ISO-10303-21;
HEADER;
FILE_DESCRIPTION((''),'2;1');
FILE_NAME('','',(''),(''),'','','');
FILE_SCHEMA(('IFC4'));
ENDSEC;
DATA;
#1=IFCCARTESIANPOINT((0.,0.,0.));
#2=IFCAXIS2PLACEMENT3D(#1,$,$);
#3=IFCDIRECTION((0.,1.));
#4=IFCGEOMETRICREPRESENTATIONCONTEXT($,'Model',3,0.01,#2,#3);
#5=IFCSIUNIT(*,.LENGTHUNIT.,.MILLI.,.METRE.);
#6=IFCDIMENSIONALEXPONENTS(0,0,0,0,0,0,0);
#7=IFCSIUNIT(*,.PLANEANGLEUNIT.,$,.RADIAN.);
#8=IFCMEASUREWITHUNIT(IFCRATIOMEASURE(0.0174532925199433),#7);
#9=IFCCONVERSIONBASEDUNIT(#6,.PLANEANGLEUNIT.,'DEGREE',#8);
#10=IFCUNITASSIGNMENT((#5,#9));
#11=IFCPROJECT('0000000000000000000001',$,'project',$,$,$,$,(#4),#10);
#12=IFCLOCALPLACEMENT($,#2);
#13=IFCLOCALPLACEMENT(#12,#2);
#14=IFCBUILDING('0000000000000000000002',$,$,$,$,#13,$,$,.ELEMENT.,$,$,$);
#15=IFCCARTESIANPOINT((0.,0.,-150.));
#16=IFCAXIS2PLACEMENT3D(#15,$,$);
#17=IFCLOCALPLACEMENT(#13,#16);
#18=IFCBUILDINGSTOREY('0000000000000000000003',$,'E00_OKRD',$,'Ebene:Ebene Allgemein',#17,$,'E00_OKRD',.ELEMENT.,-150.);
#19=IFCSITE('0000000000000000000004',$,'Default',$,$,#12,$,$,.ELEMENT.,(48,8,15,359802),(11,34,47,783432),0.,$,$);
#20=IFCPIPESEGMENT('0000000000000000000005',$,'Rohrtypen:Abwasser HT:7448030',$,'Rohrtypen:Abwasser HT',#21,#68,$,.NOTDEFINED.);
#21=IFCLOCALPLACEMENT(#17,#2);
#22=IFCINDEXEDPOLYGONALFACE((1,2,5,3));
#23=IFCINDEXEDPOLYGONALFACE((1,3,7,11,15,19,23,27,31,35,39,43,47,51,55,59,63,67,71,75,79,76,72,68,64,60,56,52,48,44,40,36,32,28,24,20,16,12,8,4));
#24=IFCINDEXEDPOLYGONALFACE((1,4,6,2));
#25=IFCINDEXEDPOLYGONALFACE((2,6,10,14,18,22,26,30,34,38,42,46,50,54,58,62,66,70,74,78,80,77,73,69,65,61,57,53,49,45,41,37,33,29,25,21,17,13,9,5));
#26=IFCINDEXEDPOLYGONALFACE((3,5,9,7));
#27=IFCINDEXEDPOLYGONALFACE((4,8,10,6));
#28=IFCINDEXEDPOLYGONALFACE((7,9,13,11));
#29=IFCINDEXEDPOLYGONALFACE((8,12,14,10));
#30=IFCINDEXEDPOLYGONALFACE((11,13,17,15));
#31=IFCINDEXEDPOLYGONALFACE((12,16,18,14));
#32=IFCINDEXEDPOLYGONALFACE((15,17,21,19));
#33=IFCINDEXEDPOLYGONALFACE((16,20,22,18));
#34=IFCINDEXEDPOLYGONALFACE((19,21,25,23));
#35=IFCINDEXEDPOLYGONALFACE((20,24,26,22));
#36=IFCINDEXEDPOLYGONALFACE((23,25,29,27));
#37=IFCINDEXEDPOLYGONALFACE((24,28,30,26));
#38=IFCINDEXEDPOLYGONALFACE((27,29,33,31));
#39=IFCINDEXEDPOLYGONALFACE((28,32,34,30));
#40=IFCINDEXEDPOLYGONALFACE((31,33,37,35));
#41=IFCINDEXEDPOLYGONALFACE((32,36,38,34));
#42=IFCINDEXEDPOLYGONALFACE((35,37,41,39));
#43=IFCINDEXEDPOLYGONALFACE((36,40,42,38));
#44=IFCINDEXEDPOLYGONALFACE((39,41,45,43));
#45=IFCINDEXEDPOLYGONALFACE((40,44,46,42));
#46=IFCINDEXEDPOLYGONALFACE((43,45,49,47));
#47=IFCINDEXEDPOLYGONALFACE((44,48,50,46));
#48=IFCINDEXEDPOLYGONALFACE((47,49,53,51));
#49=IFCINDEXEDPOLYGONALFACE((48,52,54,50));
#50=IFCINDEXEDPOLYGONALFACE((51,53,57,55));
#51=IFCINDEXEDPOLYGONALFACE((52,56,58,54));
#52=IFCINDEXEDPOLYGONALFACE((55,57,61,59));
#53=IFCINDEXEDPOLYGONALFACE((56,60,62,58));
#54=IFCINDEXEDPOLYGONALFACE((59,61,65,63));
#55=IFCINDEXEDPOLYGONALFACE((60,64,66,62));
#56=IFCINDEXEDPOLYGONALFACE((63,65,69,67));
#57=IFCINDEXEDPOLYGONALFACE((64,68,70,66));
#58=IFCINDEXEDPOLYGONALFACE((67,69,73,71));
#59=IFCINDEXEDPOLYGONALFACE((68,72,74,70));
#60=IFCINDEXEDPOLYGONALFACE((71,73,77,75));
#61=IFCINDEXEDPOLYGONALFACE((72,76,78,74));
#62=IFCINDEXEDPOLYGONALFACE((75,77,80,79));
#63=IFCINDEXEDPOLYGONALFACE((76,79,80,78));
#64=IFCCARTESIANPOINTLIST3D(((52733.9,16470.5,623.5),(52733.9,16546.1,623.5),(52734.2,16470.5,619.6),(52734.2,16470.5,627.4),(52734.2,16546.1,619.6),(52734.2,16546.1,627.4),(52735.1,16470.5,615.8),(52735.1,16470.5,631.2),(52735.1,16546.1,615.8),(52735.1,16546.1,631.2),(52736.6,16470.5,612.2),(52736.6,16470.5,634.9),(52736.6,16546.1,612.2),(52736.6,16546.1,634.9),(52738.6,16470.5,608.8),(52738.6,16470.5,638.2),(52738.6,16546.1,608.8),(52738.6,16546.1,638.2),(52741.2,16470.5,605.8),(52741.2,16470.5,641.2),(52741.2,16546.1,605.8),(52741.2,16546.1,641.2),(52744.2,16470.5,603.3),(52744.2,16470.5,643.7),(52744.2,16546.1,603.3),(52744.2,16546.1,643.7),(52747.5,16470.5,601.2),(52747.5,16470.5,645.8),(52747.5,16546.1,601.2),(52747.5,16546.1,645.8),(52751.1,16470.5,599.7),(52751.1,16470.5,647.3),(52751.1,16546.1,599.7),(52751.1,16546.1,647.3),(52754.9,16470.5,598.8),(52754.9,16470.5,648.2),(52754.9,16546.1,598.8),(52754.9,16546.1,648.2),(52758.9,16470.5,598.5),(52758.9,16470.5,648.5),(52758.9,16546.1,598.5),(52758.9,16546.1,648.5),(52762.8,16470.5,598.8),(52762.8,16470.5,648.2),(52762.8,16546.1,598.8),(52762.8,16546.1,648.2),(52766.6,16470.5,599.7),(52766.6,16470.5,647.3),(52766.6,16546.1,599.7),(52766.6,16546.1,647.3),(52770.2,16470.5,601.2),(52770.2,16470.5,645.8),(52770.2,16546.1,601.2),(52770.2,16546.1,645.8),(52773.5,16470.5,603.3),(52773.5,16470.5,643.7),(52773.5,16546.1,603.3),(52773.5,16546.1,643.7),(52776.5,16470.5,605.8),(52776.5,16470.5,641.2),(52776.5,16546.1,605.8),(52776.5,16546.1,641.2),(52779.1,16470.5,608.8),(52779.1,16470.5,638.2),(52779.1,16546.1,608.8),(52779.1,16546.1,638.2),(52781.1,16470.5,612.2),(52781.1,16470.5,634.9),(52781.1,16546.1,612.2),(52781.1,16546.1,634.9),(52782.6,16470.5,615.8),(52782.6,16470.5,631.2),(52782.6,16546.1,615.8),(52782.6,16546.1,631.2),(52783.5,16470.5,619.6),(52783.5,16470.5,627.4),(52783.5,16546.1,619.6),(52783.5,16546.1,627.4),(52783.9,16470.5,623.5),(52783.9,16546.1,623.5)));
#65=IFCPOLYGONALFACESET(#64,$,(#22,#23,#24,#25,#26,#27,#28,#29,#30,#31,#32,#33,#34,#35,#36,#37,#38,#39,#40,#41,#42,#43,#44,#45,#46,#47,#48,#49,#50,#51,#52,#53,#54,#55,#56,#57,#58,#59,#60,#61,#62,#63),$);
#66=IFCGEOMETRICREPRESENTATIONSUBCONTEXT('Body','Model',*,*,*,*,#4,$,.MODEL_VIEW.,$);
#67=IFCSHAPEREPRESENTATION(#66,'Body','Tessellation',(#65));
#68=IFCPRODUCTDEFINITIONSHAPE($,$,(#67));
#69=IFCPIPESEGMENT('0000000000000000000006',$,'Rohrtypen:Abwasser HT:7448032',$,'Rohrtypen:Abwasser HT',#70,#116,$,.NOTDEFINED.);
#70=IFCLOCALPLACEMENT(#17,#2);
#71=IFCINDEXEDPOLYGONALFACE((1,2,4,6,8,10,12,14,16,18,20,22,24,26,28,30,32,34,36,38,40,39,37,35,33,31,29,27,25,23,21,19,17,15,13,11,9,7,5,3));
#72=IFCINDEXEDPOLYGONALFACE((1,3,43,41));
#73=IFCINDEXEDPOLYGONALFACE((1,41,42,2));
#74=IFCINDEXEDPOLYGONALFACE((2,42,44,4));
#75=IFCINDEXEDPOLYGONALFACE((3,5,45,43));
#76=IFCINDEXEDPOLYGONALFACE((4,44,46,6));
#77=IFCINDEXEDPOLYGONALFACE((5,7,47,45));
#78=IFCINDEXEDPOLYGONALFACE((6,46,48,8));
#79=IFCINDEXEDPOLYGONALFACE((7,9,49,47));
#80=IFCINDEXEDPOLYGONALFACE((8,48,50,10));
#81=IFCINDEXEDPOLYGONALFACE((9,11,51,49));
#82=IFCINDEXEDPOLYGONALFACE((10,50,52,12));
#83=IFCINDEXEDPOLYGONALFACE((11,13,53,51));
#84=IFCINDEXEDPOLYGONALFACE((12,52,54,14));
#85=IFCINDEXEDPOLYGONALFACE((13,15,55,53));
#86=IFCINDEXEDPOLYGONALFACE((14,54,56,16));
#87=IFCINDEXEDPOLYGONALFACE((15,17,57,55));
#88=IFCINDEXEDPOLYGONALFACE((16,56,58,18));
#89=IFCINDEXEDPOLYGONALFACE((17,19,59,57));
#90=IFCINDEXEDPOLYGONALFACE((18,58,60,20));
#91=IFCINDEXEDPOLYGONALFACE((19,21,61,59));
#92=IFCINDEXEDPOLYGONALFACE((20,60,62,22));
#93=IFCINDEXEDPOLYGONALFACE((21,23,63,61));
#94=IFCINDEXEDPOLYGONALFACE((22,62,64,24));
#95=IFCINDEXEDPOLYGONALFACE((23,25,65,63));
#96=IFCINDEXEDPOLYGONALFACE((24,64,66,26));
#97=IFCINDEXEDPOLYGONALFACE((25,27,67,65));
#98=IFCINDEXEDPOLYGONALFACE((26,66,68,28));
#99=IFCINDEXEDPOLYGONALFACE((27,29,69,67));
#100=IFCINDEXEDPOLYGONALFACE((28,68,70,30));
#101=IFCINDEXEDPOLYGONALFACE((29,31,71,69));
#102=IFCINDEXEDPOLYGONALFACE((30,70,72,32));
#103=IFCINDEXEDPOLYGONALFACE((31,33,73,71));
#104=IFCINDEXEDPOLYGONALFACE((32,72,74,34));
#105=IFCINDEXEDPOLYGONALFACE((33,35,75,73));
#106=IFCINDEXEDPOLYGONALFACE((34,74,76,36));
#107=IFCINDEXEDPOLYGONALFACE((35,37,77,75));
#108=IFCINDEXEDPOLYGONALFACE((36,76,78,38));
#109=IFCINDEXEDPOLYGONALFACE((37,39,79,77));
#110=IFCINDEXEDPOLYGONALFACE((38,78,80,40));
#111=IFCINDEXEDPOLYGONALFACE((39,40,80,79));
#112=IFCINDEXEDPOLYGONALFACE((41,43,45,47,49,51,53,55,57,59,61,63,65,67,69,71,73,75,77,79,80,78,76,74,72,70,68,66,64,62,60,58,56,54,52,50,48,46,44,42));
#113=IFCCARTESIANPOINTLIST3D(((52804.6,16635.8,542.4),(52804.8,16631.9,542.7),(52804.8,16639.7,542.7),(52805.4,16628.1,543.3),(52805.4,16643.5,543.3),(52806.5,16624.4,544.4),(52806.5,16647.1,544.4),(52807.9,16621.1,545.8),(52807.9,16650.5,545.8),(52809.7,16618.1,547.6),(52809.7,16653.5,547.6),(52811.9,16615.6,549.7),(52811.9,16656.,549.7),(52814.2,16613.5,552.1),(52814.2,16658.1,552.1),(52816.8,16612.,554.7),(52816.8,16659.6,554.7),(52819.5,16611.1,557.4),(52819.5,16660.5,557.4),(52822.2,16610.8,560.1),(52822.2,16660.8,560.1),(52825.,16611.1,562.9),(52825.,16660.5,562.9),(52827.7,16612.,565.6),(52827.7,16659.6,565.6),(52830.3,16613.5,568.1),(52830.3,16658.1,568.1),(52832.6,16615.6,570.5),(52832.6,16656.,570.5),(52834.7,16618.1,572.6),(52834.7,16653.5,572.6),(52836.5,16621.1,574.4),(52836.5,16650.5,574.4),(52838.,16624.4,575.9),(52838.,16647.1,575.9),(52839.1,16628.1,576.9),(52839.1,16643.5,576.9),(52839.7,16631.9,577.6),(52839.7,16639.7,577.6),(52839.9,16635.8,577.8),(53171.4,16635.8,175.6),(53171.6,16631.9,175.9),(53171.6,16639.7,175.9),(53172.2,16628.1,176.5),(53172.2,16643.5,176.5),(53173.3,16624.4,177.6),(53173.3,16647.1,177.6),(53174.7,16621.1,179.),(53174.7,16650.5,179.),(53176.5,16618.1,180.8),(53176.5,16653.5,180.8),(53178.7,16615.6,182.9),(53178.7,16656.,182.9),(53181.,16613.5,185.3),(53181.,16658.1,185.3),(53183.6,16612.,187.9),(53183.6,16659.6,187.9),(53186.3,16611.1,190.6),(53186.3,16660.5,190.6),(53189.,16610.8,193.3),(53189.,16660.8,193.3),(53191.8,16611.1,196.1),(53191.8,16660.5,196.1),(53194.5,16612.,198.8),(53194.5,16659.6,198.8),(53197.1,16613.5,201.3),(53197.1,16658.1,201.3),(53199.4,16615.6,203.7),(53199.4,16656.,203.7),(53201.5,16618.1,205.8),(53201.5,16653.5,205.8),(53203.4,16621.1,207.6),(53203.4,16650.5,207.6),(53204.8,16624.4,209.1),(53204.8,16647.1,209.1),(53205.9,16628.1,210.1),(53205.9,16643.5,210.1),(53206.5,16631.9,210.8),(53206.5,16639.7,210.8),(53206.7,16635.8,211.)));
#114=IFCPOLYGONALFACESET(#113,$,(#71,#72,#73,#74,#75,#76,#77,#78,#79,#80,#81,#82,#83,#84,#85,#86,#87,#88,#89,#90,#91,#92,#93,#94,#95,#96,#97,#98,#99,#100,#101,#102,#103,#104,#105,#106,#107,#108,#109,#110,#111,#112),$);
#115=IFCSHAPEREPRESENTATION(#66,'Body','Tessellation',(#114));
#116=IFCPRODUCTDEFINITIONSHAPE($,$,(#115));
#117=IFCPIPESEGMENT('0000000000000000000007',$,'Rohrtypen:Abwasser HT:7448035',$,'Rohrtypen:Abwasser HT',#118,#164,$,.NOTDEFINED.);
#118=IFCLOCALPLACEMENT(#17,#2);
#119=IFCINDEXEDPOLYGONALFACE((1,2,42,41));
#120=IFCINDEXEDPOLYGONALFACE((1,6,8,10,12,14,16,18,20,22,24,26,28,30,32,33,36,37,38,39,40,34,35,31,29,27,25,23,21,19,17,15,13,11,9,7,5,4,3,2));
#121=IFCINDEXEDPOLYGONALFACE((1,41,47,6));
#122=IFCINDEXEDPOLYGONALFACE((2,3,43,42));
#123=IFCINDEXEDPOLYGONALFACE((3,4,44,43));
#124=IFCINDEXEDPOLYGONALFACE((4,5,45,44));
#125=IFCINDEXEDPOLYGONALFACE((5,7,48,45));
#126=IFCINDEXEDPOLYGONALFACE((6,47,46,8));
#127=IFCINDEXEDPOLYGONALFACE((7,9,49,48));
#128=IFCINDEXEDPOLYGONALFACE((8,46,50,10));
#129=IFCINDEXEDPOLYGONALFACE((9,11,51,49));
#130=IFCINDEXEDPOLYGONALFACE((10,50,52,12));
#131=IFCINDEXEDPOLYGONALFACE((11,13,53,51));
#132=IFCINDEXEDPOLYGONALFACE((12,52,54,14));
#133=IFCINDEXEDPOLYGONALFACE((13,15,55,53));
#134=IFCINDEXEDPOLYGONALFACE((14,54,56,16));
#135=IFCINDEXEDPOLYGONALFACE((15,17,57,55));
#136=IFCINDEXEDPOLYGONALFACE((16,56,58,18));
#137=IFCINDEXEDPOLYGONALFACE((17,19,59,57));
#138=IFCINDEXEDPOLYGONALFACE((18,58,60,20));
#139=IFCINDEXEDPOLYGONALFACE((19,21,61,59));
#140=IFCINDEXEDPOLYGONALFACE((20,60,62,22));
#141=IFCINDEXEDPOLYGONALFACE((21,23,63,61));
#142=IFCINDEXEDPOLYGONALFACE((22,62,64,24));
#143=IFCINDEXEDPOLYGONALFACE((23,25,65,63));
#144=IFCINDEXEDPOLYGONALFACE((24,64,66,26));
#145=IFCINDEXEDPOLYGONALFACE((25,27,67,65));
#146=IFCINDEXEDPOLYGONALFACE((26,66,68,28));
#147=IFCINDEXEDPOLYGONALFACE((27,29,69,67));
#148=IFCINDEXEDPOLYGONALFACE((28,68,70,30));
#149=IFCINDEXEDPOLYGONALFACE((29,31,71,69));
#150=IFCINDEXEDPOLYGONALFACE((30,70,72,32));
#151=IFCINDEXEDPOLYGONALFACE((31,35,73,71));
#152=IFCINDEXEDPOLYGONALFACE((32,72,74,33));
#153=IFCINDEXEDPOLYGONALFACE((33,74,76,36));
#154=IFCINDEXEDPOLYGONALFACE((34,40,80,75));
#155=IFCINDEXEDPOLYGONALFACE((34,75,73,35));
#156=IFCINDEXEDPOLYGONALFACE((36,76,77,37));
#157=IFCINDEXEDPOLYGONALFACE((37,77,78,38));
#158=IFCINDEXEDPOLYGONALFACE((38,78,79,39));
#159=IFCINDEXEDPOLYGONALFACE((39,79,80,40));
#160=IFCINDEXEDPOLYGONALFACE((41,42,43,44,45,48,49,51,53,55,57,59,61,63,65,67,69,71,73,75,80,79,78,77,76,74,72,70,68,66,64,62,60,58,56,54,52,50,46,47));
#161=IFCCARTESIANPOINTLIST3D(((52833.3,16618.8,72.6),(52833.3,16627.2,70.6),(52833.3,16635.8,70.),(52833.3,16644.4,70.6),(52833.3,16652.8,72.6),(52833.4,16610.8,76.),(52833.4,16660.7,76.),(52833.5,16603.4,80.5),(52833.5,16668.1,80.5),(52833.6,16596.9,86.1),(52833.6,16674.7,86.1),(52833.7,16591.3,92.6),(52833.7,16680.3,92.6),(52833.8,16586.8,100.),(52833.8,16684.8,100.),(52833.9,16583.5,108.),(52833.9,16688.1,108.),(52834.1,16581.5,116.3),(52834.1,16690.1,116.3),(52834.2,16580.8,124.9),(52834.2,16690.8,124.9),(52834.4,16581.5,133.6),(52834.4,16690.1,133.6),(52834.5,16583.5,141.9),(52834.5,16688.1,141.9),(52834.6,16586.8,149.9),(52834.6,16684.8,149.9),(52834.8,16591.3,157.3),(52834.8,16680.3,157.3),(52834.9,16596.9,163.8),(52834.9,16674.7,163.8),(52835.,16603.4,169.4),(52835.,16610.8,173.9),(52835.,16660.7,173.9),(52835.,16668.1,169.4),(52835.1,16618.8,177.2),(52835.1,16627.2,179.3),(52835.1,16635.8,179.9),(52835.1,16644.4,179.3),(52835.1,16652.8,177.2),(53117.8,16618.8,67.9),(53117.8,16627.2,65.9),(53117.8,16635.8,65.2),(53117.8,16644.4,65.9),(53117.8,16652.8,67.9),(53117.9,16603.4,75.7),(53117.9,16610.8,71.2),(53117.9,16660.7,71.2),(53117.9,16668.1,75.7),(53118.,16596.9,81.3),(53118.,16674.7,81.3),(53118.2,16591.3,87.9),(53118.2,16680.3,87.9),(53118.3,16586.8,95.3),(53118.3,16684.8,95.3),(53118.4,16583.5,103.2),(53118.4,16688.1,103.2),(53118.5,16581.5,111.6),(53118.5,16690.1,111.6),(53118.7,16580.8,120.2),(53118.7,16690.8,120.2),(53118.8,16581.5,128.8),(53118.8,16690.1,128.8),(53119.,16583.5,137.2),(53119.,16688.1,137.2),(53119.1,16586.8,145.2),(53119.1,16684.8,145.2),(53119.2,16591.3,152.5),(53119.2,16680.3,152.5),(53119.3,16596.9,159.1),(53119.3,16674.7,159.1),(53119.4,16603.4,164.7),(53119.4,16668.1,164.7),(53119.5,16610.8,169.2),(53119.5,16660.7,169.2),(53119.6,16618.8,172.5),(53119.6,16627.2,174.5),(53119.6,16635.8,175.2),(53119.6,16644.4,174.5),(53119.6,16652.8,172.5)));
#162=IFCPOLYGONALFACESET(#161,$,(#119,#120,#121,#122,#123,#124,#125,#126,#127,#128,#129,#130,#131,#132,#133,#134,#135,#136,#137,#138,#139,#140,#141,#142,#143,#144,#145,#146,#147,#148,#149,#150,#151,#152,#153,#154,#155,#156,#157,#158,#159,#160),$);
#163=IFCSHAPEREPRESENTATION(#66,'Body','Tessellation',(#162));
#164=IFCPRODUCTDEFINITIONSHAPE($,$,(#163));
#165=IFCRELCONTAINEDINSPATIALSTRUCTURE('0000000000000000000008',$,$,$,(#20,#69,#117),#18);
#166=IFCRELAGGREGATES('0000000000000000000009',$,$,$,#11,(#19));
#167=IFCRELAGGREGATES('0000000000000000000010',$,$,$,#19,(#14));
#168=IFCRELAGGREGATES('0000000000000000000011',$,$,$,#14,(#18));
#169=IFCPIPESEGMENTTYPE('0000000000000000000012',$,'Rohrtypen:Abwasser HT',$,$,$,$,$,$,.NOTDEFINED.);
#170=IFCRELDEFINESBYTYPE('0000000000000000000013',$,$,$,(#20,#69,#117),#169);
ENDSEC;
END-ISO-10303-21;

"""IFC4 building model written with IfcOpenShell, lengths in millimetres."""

from ifc_helpers import new_model, entity, si_unit, converted_unit, direction, frame, origin, place, context, subcontext, project, spatial, indexed_curve, outline, extrude, type_object, element, save


model = new_model("IFC4")

# Units and contexts
model_context = context("Model", 3, precision=0.01, world=origin(), true_north=direction((0.0, 1.0)))
body_context = subcontext(model_context, "Body", "Model", "MODEL_VIEW")
ifc_project = project(units=[si_unit("LENGTHUNIT", "METRE", prefix="MILLI"), converted_unit("PLANEANGLEUNIT", "DEGREE", entity("IfcRatioMeasure", 0.0174532925199433), si_unit("PLANEANGLEUNIT", "RADIAN"), dimensions=[0, 0, 0, 0, 0, 0, 0])], contexts=[model_context])

# Site, building, storey
site_placement = place(None, origin())
site = spatial("IfcSite", under=ifc_project, at=site_placement, Name="Default", CompositionType="ELEMENT", RefLatitude=(48, 8, 15, 359802), RefLongitude=(11, 34, 47, 783432), RefElevation=0.0)
building_placement = place(site_placement, origin())
building = spatial("IfcBuilding", under=site, at=building_placement, CompositionType="ELEMENT")
storey_placement = place(building_placement, frame((0.0, 0.0, -150.0)))
storey = spatial("IfcBuildingStorey", under=building, at=storey_placement, Name="E00_OKRD", ObjectType="Ebene:Ebene Allgemein", LongName="E00_OKRD", CompositionType="ELEMENT", Elevation=-150.0)

# Pipe segments
pipe_segment_type_1 = type_object("IfcPipeSegmentType", Name="Rohrtypen:Abwasser HT", PredefinedType="NOTDEFINED")
pipe_segment_1_placement = place(storey_placement, origin())
element("IfcPipeSegment", 1, at=pipe_segment_1_placement, inside=storey, type_object=pipe_segment_type_1, Name="Rohrtypen:Abwasser HT:7448030", ObjectType="Rohrtypen:Abwasser HT", PredefinedType="NOTDEFINED", context=body_context, shape_type="SweptSolid", body=[
    extrude(outline(indexed_curve([(25.0, 0.0), (24.7, 3.9), (23.8, 7.7), (22.3, 11.3), (20.2, 14.7), (17.7, 17.7), (14.7, 20.2), (11.3, 22.3), (7.7, 23.8), (3.9, 24.7), (0.0, 25.0), (-3.9, 24.7), (-7.7, 23.8), (-11.3, 22.3), (-14.7, 20.2), (-17.7, 17.7), (-20.2, 14.7), (-22.3, 11.3), (-23.8, 7.7), (-24.7, 3.9), (-25.0, 0.0), (-24.7, -3.9), (-23.8, -7.7), (-22.3, -11.3), (-20.2, -14.7), (-17.7, -17.7), (-14.7, -20.2), (-11.3, -22.3), (-7.7, -23.8), (-3.9, -24.7), (0.0, -25.0), (3.9, -24.7), (7.7, -23.8), (11.3, -22.3), (14.7, -20.2), (17.7, -17.7), (20.2, -14.7), (22.3, -11.3), (23.8, -7.7), (24.7, -3.9), (25.0, 0.0)], self_intersect=False)), frame((52758.9, 16470.5, 623.5), z_axis=(0.0, 1.0, 0.0), x_axis=(1.0, 0.0, 0.0)), (0.0, 0.0, 1.0), 75.6),
])
pipe_segment_2_placement = place(storey_placement, origin())
element("IfcPipeSegment", 2, at=pipe_segment_2_placement, inside=storey, type_object=pipe_segment_type_1, Name="Rohrtypen:Abwasser HT:7448032", ObjectType="Rohrtypen:Abwasser HT", PredefinedType="NOTDEFINED", context=body_context, shape_type="SweptSolid", body=[
    extrude(outline(indexed_curve([(25.0, 0.0), (24.7, 3.9), (23.8, 7.7), (22.3, 11.3), (20.2, 14.7), (17.7, 17.7), (14.7, 20.2), (11.3, 22.3), (7.7, 23.8), (3.9, 24.7), (0.0, 25.0), (-3.9, 24.7), (-7.7, 23.8), (-11.3, 22.3), (-14.7, 20.2), (-17.7, 17.7), (-20.2, 14.7), (-22.3, 11.3), (-23.8, 7.7), (-24.7, 3.9), (-25.0, 0.0), (-24.7, -3.9), (-23.8, -7.7), (-22.3, -11.3), (-20.2, -14.7), (-17.7, -17.7), (-14.7, -20.2), (-11.3, -22.3), (-7.7, -23.8), (-3.9, -24.7), (0.0, -25.0), (3.9, -24.7), (7.7, -23.8), (11.3, -22.3), (14.7, -20.2), (17.7, -17.7), (20.2, -14.7), (22.3, -11.3), (23.8, -7.7), (24.7, -3.9), (25.0, 0.0)], self_intersect=False)), frame((52822.2, 16635.8, 560.1), z_axis=(0.707107, 0.0, -0.707107), x_axis=(0.0, 1.0, 0.0)), (0.0, 0.0, 1.0), 518.7),
])
pipe_segment_3_placement = place(storey_placement, origin())
element("IfcPipeSegment", 3, at=pipe_segment_3_placement, inside=storey, type_object=pipe_segment_type_1, Name="Rohrtypen:Abwasser HT:7448035", ObjectType="Rohrtypen:Abwasser HT", PredefinedType="NOTDEFINED", context=body_context, shape_type="SweptSolid", body=[
    extrude(outline(indexed_curve([(55.0, 0.0), (54.3, 8.6), (52.3, 17.0), (49.0, 25.0), (44.5, 32.3), (38.9, 38.9), (32.3, 44.5), (25.0, 49.0), (17.0, 52.3), (8.6, 54.3), (0.0, 55.0), (-8.6, 54.3), (-17.0, 52.3), (-25.0, 49.0), (-32.3, 44.5), (-38.9, 38.9), (-44.5, 32.3), (-49.0, 25.0), (-52.3, 17.0), (-54.3, 8.6), (-55.0, 0.0), (-54.3, -8.6), (-52.3, -17.0), (-49.0, -25.0), (-44.5, -32.3), (-38.9, -38.9), (-32.3, -44.5), (-25.0, -49.0), (-17.0, -52.3), (-8.6, -54.3), (0.0, -55.0), (8.6, -54.3), (17.0, -52.3), (25.0, -49.0), (32.3, -44.5), (38.9, -38.9), (44.5, -32.3), (49.0, -25.0), (52.3, -17.0), (54.3, -8.6), (55.0, 0.0)], self_intersect=False)), frame((52834.2, 16635.8, 124.9), z_axis=(0.999862, 0.0, -0.016604), x_axis=(0.0, -1.0, 0.0)), (0.0, 0.0, 1.0), 284.5),
])

save(model, "model.ifc")
